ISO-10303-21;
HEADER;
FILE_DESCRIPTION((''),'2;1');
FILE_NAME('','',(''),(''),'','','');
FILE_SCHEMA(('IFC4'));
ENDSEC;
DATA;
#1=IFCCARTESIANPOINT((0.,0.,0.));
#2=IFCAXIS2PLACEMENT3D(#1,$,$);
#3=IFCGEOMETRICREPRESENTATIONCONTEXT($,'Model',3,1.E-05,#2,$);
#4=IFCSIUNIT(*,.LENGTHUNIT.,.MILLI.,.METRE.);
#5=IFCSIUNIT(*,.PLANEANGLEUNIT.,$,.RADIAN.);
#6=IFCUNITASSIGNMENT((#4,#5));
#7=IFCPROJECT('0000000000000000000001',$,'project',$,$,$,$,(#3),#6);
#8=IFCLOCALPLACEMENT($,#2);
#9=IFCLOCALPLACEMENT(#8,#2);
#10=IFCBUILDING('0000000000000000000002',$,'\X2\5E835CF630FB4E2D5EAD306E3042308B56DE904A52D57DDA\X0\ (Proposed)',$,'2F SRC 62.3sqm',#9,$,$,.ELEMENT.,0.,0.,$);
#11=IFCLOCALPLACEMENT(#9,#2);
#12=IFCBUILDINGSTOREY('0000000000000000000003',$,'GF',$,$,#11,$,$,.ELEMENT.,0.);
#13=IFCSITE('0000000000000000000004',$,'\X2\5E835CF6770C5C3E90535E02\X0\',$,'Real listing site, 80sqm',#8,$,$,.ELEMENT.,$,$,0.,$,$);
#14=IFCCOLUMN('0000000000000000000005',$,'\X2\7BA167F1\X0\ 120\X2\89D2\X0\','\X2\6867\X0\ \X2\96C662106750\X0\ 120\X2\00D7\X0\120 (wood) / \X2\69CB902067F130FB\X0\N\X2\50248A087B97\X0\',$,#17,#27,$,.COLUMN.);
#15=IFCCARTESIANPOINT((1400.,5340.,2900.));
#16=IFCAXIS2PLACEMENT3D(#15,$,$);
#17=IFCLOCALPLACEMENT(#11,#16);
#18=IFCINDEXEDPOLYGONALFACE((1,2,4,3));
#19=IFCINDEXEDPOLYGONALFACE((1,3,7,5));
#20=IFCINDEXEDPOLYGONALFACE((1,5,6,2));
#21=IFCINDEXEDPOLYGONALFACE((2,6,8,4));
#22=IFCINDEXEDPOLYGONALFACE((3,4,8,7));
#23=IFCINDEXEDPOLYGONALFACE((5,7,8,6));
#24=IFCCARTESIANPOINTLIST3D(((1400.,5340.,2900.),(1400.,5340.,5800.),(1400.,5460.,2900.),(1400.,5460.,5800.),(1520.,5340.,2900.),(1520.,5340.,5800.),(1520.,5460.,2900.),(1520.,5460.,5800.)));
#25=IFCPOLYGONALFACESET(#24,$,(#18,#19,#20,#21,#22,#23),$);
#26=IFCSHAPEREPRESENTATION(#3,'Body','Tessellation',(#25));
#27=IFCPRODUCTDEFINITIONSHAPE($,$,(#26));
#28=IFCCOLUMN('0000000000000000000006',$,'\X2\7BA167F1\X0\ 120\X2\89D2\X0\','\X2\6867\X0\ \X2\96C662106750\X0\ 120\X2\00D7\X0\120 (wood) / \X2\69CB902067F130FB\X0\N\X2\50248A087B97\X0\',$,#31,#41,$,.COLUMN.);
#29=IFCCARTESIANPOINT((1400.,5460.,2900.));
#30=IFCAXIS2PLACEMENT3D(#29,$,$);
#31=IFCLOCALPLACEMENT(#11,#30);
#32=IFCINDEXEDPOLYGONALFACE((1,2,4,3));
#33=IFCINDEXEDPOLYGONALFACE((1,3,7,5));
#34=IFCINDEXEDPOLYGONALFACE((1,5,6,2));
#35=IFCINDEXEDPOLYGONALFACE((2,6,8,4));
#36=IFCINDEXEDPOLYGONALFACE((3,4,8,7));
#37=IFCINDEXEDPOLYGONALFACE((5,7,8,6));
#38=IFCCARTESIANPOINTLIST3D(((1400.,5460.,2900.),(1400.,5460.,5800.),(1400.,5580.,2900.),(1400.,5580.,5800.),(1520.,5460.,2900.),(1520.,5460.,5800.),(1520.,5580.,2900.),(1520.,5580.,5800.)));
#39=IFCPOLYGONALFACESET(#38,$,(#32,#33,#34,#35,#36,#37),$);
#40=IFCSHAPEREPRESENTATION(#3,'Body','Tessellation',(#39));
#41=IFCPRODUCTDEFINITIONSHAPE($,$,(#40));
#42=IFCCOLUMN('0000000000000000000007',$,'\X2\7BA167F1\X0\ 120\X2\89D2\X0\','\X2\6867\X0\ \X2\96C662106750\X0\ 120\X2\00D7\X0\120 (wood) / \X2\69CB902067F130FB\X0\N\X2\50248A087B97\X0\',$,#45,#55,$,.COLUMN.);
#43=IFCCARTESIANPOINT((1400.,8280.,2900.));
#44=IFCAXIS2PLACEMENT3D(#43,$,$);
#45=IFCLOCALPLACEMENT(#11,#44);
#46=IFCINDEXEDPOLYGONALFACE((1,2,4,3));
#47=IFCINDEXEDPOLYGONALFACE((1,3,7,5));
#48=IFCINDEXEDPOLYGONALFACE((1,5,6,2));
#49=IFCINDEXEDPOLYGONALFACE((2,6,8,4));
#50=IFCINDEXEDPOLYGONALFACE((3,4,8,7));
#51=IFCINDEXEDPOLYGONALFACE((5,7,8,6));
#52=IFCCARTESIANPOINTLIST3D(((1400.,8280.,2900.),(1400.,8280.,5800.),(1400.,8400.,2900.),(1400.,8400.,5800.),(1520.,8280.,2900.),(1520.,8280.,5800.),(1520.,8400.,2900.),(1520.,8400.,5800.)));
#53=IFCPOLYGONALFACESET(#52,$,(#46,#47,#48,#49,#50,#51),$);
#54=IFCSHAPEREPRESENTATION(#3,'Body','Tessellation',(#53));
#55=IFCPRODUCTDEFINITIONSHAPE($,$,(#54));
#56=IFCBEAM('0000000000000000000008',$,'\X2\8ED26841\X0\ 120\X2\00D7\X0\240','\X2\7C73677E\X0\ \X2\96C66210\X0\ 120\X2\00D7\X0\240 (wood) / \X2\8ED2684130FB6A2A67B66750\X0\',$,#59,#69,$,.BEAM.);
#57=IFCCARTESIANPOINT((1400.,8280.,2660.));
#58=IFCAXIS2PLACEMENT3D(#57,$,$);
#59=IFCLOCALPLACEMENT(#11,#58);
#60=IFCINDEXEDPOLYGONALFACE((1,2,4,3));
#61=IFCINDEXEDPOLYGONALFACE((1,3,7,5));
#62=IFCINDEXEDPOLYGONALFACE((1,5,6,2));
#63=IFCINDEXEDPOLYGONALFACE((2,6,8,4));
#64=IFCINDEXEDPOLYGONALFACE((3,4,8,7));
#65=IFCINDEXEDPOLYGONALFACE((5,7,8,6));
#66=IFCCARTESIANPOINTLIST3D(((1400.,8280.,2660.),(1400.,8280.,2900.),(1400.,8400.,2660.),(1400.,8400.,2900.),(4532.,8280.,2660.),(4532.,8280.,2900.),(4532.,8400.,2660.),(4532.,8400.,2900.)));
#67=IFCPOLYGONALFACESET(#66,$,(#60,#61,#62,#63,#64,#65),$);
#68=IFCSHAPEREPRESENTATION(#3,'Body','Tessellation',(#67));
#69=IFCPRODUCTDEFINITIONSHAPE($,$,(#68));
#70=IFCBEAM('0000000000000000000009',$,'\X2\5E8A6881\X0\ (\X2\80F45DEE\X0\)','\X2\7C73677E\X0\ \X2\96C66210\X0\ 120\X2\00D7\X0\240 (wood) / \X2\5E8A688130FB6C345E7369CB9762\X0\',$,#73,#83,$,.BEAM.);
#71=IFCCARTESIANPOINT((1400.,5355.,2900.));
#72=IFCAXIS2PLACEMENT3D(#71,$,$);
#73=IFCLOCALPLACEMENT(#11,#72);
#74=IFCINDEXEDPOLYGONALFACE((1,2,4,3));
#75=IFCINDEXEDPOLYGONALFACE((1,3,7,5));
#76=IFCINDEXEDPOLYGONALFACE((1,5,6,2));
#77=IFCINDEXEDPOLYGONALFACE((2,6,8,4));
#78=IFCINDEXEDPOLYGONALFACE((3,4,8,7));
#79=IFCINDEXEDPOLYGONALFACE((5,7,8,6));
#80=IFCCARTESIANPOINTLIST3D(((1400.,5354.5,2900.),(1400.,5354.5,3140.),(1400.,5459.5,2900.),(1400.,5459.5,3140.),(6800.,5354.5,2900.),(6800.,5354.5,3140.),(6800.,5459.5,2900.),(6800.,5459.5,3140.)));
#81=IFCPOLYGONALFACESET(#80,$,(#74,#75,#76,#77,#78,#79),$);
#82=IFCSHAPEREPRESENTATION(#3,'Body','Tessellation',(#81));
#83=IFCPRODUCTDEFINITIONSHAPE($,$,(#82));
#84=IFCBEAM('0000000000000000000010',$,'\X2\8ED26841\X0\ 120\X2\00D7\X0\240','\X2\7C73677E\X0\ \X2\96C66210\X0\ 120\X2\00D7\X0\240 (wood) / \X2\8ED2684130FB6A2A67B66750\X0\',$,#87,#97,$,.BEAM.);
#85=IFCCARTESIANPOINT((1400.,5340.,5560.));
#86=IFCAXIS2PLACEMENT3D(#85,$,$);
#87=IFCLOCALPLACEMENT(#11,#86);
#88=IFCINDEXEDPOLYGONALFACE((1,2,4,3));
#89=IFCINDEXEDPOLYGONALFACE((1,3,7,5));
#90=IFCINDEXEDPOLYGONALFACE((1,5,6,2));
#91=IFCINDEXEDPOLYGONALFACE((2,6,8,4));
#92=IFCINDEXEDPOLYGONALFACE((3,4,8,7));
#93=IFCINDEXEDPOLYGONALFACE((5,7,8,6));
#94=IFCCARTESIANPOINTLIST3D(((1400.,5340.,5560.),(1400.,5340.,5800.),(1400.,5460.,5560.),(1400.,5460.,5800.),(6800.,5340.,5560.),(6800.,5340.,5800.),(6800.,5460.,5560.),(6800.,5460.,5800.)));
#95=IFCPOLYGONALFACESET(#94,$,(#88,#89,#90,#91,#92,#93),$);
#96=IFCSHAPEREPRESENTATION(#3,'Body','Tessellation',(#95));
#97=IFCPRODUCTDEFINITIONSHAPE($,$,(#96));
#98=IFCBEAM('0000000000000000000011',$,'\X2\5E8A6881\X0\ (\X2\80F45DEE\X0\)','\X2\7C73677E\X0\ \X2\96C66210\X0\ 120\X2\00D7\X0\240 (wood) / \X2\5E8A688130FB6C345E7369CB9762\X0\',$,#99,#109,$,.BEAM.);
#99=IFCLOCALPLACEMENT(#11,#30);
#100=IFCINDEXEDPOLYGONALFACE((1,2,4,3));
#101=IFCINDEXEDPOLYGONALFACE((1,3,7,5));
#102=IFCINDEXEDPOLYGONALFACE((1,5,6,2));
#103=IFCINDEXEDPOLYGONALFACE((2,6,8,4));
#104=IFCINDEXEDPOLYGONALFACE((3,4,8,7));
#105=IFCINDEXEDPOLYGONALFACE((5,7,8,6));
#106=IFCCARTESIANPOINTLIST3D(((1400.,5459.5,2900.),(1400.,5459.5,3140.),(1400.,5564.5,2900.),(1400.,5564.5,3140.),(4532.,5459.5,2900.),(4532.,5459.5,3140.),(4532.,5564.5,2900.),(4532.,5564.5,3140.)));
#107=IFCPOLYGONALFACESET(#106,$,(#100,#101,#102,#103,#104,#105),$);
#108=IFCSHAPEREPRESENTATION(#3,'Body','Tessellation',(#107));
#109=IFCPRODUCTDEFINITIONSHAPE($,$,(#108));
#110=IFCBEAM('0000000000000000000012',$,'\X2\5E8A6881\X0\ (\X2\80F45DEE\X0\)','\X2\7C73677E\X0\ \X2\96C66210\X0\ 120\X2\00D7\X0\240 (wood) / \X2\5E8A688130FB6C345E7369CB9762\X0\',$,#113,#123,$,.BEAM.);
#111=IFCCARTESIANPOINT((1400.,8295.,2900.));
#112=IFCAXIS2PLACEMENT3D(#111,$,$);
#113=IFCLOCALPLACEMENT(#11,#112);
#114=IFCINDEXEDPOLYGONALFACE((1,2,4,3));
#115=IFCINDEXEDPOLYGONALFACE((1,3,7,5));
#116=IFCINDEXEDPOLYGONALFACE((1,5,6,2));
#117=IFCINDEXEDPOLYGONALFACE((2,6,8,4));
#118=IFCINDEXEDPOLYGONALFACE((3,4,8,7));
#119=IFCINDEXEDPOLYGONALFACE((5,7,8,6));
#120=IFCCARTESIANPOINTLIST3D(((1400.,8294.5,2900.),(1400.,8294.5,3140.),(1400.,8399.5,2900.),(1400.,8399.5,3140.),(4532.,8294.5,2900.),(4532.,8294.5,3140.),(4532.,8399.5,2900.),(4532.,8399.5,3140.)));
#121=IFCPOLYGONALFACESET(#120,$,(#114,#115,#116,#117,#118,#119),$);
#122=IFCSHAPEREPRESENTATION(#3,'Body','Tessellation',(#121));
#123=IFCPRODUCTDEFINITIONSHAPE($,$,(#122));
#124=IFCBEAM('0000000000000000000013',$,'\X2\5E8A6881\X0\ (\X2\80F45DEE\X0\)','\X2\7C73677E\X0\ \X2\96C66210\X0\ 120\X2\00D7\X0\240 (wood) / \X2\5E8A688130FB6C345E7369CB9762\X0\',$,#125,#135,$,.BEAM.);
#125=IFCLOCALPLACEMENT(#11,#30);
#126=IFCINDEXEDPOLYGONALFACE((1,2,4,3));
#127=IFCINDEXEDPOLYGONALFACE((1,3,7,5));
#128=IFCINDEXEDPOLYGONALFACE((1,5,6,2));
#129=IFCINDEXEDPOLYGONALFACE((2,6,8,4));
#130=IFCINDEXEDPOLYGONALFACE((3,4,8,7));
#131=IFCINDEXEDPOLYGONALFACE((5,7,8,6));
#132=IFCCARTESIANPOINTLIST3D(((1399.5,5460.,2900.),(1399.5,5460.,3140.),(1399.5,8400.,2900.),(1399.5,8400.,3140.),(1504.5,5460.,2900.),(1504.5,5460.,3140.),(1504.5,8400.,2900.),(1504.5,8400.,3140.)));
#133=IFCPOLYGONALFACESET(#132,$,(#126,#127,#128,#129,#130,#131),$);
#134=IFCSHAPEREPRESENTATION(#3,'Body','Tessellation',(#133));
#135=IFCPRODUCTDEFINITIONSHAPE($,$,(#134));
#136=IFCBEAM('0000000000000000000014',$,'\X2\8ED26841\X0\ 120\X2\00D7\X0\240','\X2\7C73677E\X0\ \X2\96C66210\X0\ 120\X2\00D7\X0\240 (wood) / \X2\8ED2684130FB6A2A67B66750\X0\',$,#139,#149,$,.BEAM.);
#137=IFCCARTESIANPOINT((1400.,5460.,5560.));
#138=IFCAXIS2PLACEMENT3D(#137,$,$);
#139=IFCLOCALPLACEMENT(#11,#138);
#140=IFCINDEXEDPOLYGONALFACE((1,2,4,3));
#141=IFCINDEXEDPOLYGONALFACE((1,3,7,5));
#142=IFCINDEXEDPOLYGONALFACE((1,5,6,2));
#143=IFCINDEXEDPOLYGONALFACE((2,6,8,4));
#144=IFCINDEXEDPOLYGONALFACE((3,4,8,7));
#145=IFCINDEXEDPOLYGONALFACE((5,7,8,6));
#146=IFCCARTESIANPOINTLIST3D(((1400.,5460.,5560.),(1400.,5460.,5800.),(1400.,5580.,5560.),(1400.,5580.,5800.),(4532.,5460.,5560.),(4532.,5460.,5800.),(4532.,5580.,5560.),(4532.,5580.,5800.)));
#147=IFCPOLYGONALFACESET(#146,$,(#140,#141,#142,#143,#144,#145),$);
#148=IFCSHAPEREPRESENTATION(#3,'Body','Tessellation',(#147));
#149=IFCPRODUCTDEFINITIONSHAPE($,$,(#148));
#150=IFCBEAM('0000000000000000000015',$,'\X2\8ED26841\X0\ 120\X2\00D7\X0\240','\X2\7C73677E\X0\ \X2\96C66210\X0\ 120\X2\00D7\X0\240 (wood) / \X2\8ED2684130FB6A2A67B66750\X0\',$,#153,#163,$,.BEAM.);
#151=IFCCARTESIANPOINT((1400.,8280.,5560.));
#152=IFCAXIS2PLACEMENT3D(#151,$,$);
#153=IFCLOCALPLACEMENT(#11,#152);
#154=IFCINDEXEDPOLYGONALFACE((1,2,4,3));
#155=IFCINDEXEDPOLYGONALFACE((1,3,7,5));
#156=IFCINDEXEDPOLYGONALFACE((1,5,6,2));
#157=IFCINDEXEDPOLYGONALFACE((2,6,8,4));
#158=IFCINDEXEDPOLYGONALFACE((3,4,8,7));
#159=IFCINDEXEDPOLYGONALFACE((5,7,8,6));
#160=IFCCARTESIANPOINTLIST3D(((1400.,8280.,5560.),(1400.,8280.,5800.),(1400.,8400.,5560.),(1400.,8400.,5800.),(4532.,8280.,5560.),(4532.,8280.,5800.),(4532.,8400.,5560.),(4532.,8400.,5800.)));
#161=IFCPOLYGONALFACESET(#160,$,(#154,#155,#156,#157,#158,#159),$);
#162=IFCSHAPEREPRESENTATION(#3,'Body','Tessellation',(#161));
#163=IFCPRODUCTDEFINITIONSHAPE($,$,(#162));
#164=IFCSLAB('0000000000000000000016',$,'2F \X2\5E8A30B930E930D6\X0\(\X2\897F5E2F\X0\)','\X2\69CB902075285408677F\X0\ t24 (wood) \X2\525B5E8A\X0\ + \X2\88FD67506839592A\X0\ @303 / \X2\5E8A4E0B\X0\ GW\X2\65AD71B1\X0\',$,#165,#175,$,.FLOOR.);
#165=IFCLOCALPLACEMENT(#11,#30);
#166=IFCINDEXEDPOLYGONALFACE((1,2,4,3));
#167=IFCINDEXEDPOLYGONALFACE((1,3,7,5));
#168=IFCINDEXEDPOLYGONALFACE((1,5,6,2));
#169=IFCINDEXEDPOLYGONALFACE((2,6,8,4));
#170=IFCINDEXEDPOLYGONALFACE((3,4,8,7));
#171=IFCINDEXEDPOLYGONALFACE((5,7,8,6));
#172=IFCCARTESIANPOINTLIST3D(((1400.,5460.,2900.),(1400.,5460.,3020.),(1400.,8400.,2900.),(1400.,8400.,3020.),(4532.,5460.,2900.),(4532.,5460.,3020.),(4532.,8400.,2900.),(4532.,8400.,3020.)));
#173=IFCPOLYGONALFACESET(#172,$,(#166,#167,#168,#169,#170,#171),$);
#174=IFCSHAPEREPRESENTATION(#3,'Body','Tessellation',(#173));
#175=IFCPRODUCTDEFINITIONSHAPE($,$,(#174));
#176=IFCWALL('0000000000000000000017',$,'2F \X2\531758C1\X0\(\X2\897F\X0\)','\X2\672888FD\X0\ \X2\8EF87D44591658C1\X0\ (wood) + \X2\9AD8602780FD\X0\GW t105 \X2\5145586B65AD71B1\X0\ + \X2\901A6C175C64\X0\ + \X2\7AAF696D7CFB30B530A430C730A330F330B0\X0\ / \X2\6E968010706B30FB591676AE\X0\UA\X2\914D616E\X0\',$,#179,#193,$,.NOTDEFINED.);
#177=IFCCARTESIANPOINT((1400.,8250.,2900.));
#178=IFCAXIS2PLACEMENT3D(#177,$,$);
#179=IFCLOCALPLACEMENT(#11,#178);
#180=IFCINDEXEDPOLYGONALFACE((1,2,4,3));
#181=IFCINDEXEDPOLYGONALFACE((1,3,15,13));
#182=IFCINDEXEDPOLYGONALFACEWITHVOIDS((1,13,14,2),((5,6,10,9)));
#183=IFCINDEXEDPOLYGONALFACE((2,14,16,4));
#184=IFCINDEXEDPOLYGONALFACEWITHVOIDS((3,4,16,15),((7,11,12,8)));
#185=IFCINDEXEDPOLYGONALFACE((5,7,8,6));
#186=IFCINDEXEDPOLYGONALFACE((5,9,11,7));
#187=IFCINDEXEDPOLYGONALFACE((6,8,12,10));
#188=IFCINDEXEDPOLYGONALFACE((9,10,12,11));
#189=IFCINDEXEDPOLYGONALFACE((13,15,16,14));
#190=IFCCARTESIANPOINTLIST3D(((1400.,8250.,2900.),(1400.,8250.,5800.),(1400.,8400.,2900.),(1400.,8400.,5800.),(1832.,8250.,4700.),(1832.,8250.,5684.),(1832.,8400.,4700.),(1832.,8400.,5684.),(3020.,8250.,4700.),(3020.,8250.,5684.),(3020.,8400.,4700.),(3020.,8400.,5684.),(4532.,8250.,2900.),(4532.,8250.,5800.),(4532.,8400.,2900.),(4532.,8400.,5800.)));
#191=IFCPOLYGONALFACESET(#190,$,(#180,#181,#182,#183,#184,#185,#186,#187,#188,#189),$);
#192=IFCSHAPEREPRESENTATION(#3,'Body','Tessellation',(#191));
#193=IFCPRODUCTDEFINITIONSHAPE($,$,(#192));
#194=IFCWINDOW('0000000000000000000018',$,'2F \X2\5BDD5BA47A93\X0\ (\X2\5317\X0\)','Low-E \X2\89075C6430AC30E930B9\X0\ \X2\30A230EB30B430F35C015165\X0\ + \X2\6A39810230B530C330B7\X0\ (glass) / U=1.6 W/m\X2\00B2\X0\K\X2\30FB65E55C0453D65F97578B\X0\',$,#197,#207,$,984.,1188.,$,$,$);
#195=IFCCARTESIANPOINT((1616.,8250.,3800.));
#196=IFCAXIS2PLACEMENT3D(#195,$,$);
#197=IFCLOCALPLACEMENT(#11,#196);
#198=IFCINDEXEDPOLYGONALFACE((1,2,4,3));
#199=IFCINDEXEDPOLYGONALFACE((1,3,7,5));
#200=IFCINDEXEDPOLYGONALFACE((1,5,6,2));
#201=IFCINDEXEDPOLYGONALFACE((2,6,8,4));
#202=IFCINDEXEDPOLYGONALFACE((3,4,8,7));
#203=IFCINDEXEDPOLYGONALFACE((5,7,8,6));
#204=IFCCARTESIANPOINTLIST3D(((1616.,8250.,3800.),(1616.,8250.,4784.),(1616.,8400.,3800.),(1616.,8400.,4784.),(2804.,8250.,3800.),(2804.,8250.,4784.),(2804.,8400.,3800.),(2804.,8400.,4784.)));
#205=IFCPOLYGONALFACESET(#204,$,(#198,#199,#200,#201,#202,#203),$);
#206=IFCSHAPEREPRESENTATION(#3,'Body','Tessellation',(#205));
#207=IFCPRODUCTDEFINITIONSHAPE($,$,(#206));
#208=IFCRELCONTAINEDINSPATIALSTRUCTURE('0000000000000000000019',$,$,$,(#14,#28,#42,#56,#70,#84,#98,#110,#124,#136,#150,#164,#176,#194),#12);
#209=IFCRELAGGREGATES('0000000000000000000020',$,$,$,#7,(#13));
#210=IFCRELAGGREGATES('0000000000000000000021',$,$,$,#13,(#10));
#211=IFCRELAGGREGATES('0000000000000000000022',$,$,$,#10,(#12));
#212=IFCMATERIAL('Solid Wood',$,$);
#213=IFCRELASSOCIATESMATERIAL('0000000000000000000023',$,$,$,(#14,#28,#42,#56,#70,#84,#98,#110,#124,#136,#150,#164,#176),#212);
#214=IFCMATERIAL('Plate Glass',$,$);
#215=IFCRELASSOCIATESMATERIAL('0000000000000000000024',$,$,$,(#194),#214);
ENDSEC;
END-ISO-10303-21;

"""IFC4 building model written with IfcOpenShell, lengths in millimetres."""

from ifc_helpers import new_model, si_unit, frame, frame_2d, origin, place, context, project, spatial, rectangle, extrude, material, element, fill, save


model = new_model("IFC4")

# Units and contexts
model_context = context("Model", 3, precision=1e-05, world=origin())
ifc_project = project(units=[si_unit("LENGTHUNIT", "METRE", prefix="MILLI"), si_unit("PLANEANGLEUNIT", "RADIAN")], contexts=[model_context])

# Site, building, storey
site_placement = place(None, origin())
site = spatial("IfcSite", under=ifc_project, at=site_placement, Name="広島県尾道市", ObjectType="Real listing site, 80sqm", CompositionType="ELEMENT", RefElevation=0.0)
building_placement = place(site_placement, origin())
building = spatial("IfcBuilding", under=site, at=building_placement, Name="広島・中庭のある回遊動線 (Proposed)", ObjectType="2F SRC 62.3sqm", CompositionType="ELEMENT", ElevationOfRefHeight=0.0, ElevationOfTerrain=0.0)
storey_placement = place(building_placement, origin())
storey = spatial("IfcBuildingStorey", under=building, at=storey_placement, Name="GF", CompositionType="ELEMENT", Elevation=0.0)

# Columns
ifc_material_1 = material(Name="Solid Wood")
column_1_placement = place(storey_placement, frame((1400.0, 5340.0, 2900.0)))
element("IfcColumn", 1, at=column_1_placement, inside=storey, material=ifc_material_1, Name="管柱 120角", Description="桧 集成材 120×120 (wood) / 構造柱・N値計算", PredefinedType="COLUMN", context=model_context, shape_type="SweptSolid", body=[
    extrude(rectangle(XDim=120.0, YDim=120.0, at=frame_2d((60.0, 60.0))), frame((1400.0, 5340.0, 2900.0)), (0.0, 0.0, 1.0), 2900.0),
])
column_2_placement = place(storey_placement, frame((1400.0, 5460.0, 2900.0)))
element("IfcColumn", 2, at=column_2_placement, inside=storey, material=ifc_material_1, Name="管柱 120角", Description="桧 集成材 120×120 (wood) / 構造柱・N値計算", PredefinedType="COLUMN", context=model_context, shape_type="SweptSolid", body=[
    extrude(rectangle(XDim=120.0, YDim=120.0, at=frame_2d((60.0, 60.0))), frame((1400.0, 5460.0, 2900.0)), (0.0, 0.0, 1.0), 2900.0),
])
column_3_placement = place(storey_placement, frame((1400.0, 8280.0, 2900.0)))
element("IfcColumn", 3, at=column_3_placement, inside=storey, material=ifc_material_1, Name="管柱 120角", Description="桧 集成材 120×120 (wood) / 構造柱・N値計算", PredefinedType="COLUMN", context=model_context, shape_type="SweptSolid", body=[
    extrude(rectangle(XDim=120.0, YDim=120.0, at=frame_2d((60.0, 60.0))), frame((1400.0, 8280.0, 2900.0)), (0.0, 0.0, 1.0), 2900.0),
])

# Beams
beam_1_placement = place(storey_placement, frame((1400.0, 8280.0, 2660.0)))
element("IfcBeam", 4, at=beam_1_placement, inside=storey, material=ifc_material_1, Name="軒桁 120×240", Description="米松 集成 120×240 (wood) / 軒桁・横架材", PredefinedType="BEAM", context=model_context, shape_type="SweptSolid", body=[
    extrude(rectangle(XDim=3132.0, YDim=120.0, at=frame_2d((1566.0, 60.0))), frame((1400.0, 8280.0, 2660.0)), (0.0, 0.0, 1.0), 240.0),
])
beam_2_placement = place(storey_placement, frame((1400.0, 5355.0, 2900.0)))
element("IfcBeam", 5, at=beam_2_placement, inside=storey, material=ifc_material_1, Name="床梁 (胴差)", Description="米松 集成 120×240 (wood) / 床梁・水平構面", PredefinedType="BEAM", context=model_context, shape_type="SweptSolid", body=[
    extrude(rectangle(XDim=5400.0, YDim=105.0, at=frame_2d((2700.0, 52.0))), frame((1400.0, 5355.0, 2900.0)), (0.0, 0.0, 1.0), 240.0),
])
beam_3_placement = place(storey_placement, frame((1400.0, 5340.0, 5560.0)))
element("IfcBeam", 6, at=beam_3_placement, inside=storey, material=ifc_material_1, Name="軒桁 120×240", Description="米松 集成 120×240 (wood) / 軒桁・横架材", PredefinedType="BEAM", context=model_context, shape_type="SweptSolid", body=[
    extrude(rectangle(XDim=5400.0, YDim=120.0, at=frame_2d((2700.0, 60.0))), frame((1400.0, 5340.0, 5560.0)), (0.0, 0.0, 1.0), 240.0),
])
beam_4_placement = place(storey_placement, frame((1400.0, 5460.0, 2900.0)))
element("IfcBeam", 7, at=beam_4_placement, inside=storey, material=ifc_material_1, Name="床梁 (胴差)", Description="米松 集成 120×240 (wood) / 床梁・水平構面", PredefinedType="BEAM", context=model_context, shape_type="SweptSolid", body=[
    extrude(rectangle(XDim=3132.0, YDim=105.0, at=frame_2d((1566.0, 52.0))), frame((1400.0, 5460.0, 2900.0)), (0.0, 0.0, 1.0), 240.0),
])
beam_5_placement = place(storey_placement, frame((1400.0, 8295.0, 2900.0)))
element("IfcBeam", 8, at=beam_5_placement, inside=storey, material=ifc_material_1, Name="床梁 (胴差)", Description="米松 集成 120×240 (wood) / 床梁・水平構面", PredefinedType="BEAM", context=model_context, shape_type="SweptSolid", body=[
    extrude(rectangle(XDim=3132.0, YDim=105.0, at=frame_2d((1566.0, 52.0))), frame((1400.0, 8295.0, 2900.0)), (0.0, 0.0, 1.0), 240.0),
])
beam_6_placement = place(storey_placement, frame((1400.0, 5460.0, 2900.0)))
element("IfcBeam", 9, at=beam_6_placement, inside=storey, material=ifc_material_1, Name="床梁 (胴差)", Description="米松 集成 120×240 (wood) / 床梁・水平構面", PredefinedType="BEAM", context=model_context, shape_type="SweptSolid", body=[
    extrude(rectangle(XDim=105.0, YDim=2940.0, at=frame_2d((52.0, 1470.0))), frame((1400.0, 5460.0, 2900.0)), (0.0, 0.0, 1.0), 240.0),
])
beam_7_placement = place(storey_placement, frame((1400.0, 5460.0, 5560.0)))
element("IfcBeam", 10, at=beam_7_placement, inside=storey, material=ifc_material_1, Name="軒桁 120×240", Description="米松 集成 120×240 (wood) / 軒桁・横架材", PredefinedType="BEAM", context=model_context, shape_type="SweptSolid", body=[
    extrude(rectangle(XDim=3132.0, YDim=120.0, at=frame_2d((1566.0, 60.0))), frame((1400.0, 5460.0, 5560.0)), (0.0, 0.0, 1.0), 240.0),
])
beam_8_placement = place(storey_placement, frame((1400.0, 8280.0, 5560.0)))
element("IfcBeam", 11, at=beam_8_placement, inside=storey, material=ifc_material_1, Name="軒桁 120×240", Description="米松 集成 120×240 (wood) / 軒桁・横架材", PredefinedType="BEAM", context=model_context, shape_type="SweptSolid", body=[
    extrude(rectangle(XDim=3132.0, YDim=120.0, at=frame_2d((1566.0, 60.0))), frame((1400.0, 8280.0, 5560.0)), (0.0, 0.0, 1.0), 240.0),
])

# Slab
slab_placement = place(storey_placement, frame((1400.0, 5460.0, 2900.0)))
element("IfcSlab", 12, at=slab_placement, inside=storey, material=ifc_material_1, Name="2F 床スラブ(西帯)", Description="構造用合板 t24 (wood) 剛床 + 製材根太 @303 / 床下 GW断熱", PredefinedType="FLOOR", context=model_context, shape_type="SweptSolid", body=[
    extrude(rectangle(XDim=3132.0, YDim=2940.0, at=frame_2d((1566.0, 1470.0))), frame((1400.0, 5460.0, 2900.0)), (0.0, 0.0, 1.0), 120.0),
])

# Wall, opening, window
wall_1_placement = place(storey_placement, frame((1400.0, 8250.0, 2900.0)))
wall_1 = element("IfcWall", 13, at=wall_1_placement, inside=storey, material=ifc_material_1, Name="2F 北壁(西)", Description="木製 軸組外壁 (wood) + 高性能GW t105 充填断熱 + 通気層 + 窯業系サイディング / 準耐火・外皮UA配慮", PredefinedType="NOTDEFINED", context=model_context, shape_type="SweptSolid", body=[
    extrude(rectangle(XDim=3132.0, YDim=150.0, at=frame_2d((1566.0, 75.0))), frame((1400.0, 8250.0, 2900.0)), (0.0, 0.0, 1.0), 2900.0),
])
opening_placement = place(storey_placement, frame((1616.0, 8250.0, 3800.0)))
opening = element("IfcOpeningElement", 14, at=opening_placement, cuts=wall_1, PredefinedType="NOTDEFINED", context=model_context, shape_type="SweptSolid", body=[
    extrude(rectangle(XDim=1188.0, YDim=150.0, at=frame_2d((594.0, 75.0))), frame((1616.0, 8250.0, 3800.0)), (0.0, 0.0, 1.0), 984.0),
])
ifc_material_2 = material(Name="Plate Glass")
window_placement = place(storey_placement, frame((1616.0, 8250.0, 3800.0)))
window = element("IfcWindow", 15, at=window_placement, inside=storey, material=ifc_material_2, Name="2F 寝室窓 (北)", Description="Low-E 複層ガラス アルゴン封入 + 樹脂サッシ (glass) / U=1.6 W/m²K・日射取得型", OverallHeight=984.0, OverallWidth=1188.0, context=model_context, shape_type="SweptSolid", body=[
    extrude(rectangle(XDim=1188.0, YDim=150.0, at=frame_2d((594.0, 75.0))), frame((1616.0, 8250.0, 3800.0)), (0.0, 0.0, 1.0), 984.0),
])
fill(opening, window)

save(model, "model.ifc")
